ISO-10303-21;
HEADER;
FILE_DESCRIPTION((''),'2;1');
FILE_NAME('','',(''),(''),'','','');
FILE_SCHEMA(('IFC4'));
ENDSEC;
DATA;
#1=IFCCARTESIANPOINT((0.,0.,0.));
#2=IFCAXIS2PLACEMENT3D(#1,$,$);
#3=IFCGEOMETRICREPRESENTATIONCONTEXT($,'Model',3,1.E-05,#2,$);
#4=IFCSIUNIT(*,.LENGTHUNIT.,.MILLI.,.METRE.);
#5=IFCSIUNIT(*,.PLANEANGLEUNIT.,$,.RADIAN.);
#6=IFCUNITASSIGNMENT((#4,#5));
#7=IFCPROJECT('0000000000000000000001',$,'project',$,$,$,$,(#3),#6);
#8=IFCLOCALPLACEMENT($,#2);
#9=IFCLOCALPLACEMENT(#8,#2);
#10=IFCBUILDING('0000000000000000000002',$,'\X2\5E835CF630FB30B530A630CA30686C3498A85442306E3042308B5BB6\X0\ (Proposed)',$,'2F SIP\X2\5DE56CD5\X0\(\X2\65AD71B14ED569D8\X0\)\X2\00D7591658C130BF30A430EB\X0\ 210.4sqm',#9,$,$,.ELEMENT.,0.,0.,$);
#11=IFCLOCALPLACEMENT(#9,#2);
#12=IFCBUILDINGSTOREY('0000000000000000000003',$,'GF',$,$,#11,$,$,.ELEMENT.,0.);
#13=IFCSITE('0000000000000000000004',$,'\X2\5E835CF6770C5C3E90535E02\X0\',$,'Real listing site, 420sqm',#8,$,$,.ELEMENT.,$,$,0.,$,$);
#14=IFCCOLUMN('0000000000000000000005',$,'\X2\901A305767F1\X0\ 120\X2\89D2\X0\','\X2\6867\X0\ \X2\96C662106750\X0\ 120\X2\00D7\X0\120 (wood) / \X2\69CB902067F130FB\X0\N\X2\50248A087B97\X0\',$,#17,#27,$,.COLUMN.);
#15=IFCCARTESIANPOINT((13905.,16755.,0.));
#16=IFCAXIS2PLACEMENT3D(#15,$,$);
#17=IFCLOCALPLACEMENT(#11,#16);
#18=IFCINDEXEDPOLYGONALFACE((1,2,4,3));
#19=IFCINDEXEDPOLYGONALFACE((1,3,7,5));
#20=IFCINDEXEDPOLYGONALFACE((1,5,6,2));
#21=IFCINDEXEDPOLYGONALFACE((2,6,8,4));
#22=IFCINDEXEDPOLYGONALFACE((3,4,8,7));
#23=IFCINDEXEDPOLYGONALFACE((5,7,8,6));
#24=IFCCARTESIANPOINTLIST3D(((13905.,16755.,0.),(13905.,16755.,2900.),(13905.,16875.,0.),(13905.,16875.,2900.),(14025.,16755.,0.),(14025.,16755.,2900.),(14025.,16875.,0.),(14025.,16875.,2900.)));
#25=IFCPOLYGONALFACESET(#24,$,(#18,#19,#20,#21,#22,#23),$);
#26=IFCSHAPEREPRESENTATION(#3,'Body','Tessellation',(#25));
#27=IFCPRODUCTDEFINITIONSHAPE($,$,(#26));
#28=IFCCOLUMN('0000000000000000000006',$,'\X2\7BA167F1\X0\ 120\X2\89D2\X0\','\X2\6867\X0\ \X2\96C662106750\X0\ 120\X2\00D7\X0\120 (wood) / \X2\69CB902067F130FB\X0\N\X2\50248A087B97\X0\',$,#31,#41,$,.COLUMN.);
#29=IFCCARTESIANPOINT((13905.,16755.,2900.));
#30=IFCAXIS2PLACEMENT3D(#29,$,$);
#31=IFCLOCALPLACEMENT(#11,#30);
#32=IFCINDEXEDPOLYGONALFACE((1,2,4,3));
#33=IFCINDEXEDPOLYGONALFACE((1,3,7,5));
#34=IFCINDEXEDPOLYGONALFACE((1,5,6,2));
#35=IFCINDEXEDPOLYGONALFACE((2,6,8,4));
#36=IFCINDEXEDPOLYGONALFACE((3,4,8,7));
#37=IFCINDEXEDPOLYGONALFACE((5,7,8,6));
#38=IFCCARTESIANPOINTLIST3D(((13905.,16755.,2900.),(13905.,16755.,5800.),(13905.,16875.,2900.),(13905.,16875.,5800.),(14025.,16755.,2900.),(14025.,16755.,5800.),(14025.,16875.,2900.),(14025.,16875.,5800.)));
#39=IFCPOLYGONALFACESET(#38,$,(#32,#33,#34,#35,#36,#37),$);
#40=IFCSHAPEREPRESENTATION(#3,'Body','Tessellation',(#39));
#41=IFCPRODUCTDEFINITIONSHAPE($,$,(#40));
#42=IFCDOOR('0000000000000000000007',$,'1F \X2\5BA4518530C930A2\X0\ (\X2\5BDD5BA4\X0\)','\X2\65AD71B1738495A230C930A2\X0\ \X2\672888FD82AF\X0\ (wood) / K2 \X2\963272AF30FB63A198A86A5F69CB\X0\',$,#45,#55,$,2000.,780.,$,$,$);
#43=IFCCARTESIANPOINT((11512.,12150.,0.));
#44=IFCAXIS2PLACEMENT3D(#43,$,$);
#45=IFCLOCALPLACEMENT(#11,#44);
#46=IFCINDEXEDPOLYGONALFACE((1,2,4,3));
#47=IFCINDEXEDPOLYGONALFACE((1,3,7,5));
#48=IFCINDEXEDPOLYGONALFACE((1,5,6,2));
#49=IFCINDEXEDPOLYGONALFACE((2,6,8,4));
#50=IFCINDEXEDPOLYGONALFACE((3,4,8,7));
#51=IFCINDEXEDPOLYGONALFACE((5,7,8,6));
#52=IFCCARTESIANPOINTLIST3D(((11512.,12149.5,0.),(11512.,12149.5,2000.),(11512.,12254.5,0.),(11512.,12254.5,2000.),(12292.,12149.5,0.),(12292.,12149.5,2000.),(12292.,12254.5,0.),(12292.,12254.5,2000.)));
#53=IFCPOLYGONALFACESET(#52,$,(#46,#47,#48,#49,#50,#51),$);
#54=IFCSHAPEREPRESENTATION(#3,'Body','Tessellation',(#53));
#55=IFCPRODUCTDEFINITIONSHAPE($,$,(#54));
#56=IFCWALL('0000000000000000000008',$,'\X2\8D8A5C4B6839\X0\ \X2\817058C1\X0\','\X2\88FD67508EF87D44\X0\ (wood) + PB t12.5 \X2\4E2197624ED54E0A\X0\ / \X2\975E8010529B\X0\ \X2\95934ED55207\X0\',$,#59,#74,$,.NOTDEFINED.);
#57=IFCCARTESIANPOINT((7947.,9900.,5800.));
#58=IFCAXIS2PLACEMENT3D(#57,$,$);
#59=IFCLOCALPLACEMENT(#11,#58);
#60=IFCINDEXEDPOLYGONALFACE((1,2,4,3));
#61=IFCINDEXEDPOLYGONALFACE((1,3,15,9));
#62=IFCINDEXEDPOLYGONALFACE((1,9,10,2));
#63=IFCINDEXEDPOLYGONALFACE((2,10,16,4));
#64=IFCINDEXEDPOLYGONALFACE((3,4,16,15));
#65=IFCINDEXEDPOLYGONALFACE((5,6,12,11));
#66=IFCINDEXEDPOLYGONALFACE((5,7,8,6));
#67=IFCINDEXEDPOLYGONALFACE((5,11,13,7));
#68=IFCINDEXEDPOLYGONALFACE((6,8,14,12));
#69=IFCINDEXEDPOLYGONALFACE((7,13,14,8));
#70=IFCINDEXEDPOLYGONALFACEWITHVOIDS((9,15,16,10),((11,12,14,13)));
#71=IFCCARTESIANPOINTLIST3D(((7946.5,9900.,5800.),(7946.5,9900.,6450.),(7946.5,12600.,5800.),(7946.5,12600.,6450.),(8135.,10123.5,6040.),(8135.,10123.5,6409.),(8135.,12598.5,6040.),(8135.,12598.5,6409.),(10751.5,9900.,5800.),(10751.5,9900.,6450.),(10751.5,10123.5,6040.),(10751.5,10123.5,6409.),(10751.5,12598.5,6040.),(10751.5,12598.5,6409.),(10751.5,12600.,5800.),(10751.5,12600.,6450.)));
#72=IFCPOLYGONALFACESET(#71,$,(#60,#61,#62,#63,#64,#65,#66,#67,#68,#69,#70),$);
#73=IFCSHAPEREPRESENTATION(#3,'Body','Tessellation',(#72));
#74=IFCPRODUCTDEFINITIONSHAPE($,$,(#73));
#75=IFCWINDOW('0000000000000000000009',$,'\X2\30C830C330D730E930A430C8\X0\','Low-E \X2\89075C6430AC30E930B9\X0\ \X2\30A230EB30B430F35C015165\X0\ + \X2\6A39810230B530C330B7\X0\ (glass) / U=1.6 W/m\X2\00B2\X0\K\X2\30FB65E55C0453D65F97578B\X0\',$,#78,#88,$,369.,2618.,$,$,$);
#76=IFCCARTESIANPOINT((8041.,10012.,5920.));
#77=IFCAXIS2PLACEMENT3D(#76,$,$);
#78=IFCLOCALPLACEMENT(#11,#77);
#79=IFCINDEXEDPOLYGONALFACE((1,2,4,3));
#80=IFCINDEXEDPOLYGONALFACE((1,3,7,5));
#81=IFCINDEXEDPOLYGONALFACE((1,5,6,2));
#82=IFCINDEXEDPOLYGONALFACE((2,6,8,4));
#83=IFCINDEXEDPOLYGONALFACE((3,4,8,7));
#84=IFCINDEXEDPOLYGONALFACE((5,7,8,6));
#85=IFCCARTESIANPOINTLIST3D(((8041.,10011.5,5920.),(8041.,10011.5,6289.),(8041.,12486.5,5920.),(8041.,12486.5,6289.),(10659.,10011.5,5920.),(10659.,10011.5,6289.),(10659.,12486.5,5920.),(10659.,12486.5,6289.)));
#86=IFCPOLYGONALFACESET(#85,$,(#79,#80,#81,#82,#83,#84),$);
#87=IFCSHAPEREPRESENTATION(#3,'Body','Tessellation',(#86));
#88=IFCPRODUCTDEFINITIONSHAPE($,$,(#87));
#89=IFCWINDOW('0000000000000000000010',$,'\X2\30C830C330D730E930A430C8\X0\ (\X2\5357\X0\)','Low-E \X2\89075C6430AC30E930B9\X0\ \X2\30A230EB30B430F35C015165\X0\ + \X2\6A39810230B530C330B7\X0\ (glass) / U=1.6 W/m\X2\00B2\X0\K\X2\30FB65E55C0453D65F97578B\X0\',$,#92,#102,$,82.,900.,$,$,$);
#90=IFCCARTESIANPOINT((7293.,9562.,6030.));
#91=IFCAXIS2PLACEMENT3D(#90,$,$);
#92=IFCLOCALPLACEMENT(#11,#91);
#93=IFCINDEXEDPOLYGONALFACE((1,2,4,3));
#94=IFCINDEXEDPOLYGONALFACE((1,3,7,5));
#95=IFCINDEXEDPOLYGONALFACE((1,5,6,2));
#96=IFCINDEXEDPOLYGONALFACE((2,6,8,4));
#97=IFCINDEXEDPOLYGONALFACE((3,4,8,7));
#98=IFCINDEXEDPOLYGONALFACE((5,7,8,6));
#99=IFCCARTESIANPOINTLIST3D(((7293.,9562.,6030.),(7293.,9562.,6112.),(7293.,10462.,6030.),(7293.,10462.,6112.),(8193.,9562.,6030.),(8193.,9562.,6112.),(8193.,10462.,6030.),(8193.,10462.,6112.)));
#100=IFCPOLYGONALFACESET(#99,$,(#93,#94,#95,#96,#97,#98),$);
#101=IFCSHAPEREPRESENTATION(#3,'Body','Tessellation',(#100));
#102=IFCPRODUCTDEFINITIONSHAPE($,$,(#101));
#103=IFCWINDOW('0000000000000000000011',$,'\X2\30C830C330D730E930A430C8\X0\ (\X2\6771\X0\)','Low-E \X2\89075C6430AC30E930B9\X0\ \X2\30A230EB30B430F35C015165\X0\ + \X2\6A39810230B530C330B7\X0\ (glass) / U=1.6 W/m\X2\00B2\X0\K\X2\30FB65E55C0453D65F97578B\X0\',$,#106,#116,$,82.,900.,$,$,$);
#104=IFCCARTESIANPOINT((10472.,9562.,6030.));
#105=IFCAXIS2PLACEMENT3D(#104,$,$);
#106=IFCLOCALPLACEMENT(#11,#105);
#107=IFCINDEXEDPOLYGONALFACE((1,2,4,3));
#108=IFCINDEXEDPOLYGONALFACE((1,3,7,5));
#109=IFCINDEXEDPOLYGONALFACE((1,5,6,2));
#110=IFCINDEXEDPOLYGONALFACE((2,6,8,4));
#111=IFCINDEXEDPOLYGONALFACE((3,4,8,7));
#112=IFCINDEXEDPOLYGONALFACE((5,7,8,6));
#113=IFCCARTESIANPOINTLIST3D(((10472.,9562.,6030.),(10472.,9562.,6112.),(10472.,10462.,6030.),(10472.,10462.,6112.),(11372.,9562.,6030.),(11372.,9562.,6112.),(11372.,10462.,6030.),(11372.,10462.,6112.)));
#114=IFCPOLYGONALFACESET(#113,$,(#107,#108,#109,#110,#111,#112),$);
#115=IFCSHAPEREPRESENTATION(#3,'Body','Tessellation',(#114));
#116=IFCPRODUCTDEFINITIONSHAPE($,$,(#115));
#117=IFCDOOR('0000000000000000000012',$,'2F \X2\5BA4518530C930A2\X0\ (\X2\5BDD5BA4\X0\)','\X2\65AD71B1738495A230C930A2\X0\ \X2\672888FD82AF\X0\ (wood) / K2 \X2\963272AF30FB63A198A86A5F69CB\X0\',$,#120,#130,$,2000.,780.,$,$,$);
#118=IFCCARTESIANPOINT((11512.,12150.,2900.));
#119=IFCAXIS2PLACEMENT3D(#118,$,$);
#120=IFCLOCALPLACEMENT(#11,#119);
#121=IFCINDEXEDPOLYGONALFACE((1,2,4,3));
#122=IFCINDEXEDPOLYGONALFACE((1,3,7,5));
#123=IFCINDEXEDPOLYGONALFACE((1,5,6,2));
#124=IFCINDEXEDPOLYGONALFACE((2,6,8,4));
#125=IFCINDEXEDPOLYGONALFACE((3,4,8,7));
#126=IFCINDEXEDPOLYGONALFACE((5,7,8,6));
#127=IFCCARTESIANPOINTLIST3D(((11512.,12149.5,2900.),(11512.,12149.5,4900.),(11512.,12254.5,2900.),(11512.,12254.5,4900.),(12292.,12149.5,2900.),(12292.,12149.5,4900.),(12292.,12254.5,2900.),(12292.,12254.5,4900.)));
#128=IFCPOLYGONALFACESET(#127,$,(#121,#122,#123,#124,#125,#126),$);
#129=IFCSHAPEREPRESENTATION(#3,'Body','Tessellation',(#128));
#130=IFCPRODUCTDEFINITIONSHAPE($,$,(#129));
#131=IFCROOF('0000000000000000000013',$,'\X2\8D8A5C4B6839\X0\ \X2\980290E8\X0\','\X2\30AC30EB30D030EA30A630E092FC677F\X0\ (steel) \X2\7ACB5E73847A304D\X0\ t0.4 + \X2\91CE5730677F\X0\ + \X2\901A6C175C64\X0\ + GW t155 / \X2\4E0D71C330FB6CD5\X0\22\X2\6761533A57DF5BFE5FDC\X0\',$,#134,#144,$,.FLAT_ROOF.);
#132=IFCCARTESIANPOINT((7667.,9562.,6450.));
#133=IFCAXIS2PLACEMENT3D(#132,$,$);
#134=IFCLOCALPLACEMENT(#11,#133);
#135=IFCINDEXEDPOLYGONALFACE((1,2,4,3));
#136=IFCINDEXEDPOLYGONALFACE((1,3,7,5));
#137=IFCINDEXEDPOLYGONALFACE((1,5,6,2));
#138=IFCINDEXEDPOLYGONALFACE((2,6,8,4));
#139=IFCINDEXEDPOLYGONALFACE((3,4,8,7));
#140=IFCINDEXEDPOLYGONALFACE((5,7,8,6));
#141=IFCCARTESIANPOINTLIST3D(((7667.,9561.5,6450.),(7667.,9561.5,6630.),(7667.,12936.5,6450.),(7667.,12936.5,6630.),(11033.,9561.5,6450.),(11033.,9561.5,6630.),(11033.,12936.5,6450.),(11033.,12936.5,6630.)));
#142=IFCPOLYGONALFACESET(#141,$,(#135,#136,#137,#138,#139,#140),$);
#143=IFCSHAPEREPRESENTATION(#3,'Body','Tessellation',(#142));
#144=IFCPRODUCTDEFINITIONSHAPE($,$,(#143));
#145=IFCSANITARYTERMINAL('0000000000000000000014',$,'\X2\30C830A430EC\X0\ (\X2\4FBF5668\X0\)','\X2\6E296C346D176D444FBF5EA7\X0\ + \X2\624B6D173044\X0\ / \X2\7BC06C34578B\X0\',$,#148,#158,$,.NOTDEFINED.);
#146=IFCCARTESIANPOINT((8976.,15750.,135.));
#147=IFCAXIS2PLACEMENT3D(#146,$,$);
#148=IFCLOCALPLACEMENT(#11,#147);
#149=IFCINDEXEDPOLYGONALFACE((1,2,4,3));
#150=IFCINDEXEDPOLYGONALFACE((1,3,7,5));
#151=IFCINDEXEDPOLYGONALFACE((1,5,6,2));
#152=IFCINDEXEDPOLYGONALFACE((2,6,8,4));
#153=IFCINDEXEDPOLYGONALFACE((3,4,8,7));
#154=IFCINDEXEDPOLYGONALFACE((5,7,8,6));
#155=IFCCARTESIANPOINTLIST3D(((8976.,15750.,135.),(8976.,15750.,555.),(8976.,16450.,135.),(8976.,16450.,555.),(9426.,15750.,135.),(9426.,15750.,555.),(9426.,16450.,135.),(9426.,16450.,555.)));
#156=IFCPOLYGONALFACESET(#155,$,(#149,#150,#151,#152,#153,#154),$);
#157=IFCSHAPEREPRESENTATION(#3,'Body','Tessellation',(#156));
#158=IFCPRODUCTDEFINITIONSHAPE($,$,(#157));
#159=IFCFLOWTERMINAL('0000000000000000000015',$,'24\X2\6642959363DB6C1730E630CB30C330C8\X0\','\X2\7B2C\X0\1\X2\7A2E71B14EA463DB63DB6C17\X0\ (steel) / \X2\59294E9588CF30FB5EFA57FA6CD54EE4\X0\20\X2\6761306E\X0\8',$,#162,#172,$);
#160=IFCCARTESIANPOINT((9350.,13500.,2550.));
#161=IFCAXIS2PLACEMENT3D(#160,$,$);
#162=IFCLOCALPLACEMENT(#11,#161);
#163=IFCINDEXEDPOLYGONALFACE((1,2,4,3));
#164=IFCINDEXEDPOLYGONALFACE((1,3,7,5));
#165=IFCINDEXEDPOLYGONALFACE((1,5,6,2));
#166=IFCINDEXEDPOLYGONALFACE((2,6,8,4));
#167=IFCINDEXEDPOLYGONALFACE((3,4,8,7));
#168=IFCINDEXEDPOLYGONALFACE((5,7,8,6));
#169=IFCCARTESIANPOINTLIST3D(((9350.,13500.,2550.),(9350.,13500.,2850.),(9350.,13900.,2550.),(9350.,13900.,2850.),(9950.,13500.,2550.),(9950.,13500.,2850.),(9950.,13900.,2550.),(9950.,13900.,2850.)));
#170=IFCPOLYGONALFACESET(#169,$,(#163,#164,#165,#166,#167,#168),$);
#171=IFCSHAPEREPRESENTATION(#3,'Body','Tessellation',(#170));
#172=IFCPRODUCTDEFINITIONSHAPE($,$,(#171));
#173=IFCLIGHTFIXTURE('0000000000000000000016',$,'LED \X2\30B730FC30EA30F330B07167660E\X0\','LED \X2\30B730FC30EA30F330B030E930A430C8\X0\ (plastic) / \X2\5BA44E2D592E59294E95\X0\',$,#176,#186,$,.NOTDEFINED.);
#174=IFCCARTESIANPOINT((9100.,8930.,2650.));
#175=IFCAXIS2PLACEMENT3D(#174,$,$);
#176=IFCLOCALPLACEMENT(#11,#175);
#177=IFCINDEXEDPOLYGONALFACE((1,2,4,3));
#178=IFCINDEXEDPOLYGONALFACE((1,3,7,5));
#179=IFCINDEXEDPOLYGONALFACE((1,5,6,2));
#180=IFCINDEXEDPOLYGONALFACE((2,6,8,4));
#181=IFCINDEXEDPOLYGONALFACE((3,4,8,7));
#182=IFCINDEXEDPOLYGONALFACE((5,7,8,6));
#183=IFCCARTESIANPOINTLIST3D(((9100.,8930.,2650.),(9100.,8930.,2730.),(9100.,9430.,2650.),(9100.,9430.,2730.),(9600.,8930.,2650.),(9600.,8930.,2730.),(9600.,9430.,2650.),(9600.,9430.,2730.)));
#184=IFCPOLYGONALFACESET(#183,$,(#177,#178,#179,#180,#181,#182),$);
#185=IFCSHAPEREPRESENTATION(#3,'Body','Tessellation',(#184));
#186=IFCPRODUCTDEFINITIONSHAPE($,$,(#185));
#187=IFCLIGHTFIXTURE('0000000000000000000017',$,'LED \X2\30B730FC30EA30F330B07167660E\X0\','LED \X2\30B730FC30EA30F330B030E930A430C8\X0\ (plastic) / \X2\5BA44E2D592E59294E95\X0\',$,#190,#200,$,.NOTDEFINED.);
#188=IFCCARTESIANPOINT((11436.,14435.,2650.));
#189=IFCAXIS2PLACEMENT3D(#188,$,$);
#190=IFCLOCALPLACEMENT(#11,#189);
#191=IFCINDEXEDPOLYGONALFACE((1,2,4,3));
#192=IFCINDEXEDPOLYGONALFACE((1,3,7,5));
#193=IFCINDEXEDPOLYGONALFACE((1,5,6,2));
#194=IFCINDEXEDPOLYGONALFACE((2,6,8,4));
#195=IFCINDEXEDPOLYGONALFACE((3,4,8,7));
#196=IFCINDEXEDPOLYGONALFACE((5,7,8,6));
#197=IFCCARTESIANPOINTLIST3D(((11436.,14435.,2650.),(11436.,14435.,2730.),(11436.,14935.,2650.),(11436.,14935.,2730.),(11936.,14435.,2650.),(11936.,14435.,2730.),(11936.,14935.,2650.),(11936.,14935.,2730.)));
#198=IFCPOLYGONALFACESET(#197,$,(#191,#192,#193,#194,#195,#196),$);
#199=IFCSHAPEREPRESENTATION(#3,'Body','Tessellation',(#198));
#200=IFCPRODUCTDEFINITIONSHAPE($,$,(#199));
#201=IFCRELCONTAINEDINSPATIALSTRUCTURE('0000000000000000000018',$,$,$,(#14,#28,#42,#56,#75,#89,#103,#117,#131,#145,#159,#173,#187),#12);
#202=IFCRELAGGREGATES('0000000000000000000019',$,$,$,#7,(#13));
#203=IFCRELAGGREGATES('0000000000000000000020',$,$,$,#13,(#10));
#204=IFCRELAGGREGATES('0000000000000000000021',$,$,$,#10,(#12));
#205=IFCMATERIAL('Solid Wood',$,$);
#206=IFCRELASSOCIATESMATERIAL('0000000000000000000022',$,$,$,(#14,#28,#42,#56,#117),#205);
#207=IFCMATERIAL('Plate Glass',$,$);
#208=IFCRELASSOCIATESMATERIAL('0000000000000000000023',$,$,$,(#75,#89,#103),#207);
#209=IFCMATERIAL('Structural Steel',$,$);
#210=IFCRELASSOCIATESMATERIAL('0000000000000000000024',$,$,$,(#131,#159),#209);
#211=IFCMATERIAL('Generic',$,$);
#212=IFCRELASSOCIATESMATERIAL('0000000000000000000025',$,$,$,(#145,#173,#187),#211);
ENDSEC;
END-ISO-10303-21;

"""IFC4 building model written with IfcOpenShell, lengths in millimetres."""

from ifc_helpers import new_model, si_unit, frame, frame_2d, origin, place, context, project, spatial, rectangle, extrude, material, element, fill, save


model = new_model("IFC4")

# Units and contexts
model_context = context("Model", 3, precision=1e-05, world=origin())
ifc_project = project(units=[si_unit("LENGTHUNIT", "METRE", prefix="MILLI"), si_unit("PLANEANGLEUNIT", "RADIAN")], contexts=[model_context])

# Site, building, storey
site_placement = place(None, origin())
site = spatial("IfcSite", under=ifc_project, at=site_placement, Name="広島県尾道市", ObjectType="Real listing site, 420sqm", CompositionType="ELEMENT", RefElevation=0.0)
building_placement = place(site_placement, origin())
building = spatial("IfcBuilding", under=site, at=building_placement, Name="広島・サウナと水風呂のある家 (Proposed)", ObjectType="2F SIP工法(断熱仕様)×外壁タイル 210.4sqm", CompositionType="ELEMENT", ElevationOfRefHeight=0.0, ElevationOfTerrain=0.0)
storey_placement = place(building_placement, origin())
storey = spatial("IfcBuildingStorey", under=building, at=storey_placement, Name="GF", CompositionType="ELEMENT", Elevation=0.0)

# Columns
ifc_material_1 = material(Name="Solid Wood")
column_1_placement = place(storey_placement, frame((13905.0, 16755.0, 0.0)))
element("IfcColumn", 1, at=column_1_placement, inside=storey, material=ifc_material_1, Name="通し柱 120角", Description="桧 集成材 120×120 (wood) / 構造柱・N値計算", PredefinedType="COLUMN", context=model_context, shape_type="SweptSolid", body=[
    extrude(rectangle(XDim=120.0, YDim=120.0, at=frame_2d((60.0, 60.0))), frame((13905.0, 16755.0, 0.0)), (0.0, 0.0, 1.0), 2900.0),
])
column_2_placement = place(storey_placement, frame((13905.0, 16755.0, 2900.0)))
element("IfcColumn", 2, at=column_2_placement, inside=storey, material=ifc_material_1, Name="管柱 120角", Description="桧 集成材 120×120 (wood) / 構造柱・N値計算", PredefinedType="COLUMN", context=model_context, shape_type="SweptSolid", body=[
    extrude(rectangle(XDim=120.0, YDim=120.0, at=frame_2d((60.0, 60.0))), frame((13905.0, 16755.0, 2900.0)), (0.0, 0.0, 1.0), 2900.0),
])

# Door
door_1_placement = place(storey_placement, frame((11512.0, 12150.0, 0.0)))
element("IfcDoor", 3, at=door_1_placement, inside=storey, material=ifc_material_1, Name="1F 室内ドア (寝室)", Description="断熱玄関ドア 木製芯 (wood) / K2 防犯・採風機構", OverallHeight=2000.0, OverallWidth=780.0, context=model_context, shape_type="SweptSolid", body=[
    extrude(rectangle(XDim=780.0, YDim=105.0, at=frame_2d((390.0, 52.0))), frame((11512.0, 12150.0, 0.0)), (0.0, 0.0, 1.0), 2000.0),
])

# Wall, openings, windows
wall_1_placement = place(storey_placement, frame((7947.0, 9900.0, 5800.0)))
wall_1 = element("IfcWall", 4, at=wall_1_placement, inside=storey, material=ifc_material_1, Name="越屋根 腰壁", Description="製材軸組 (wood) + PB t12.5 両面仕上 / 非耐力 間仕切", PredefinedType="NOTDEFINED", context=model_context, shape_type="SweptSolid", body=[
    extrude(rectangle(XDim=2805.0, YDim=2700.0, at=frame_2d((1402.0, 1350.0))), frame((7947.0, 9900.0, 5800.0)), (0.0, 0.0, 1.0), 650.0),
])
opening_1_placement = place(storey_placement, frame((8041.0, 10012.0, 5920.0)))
opening_1 = element("IfcOpeningElement", 5, at=opening_1_placement, cuts=wall_1, PredefinedType="NOTDEFINED", context=model_context, shape_type="SweptSolid", body=[
    extrude(rectangle(XDim=2618.0, YDim=2475.0, at=frame_2d((1309.0, 1237.0))), frame((8041.0, 10012.0, 5920.0)), (0.0, 0.0, 1.0), 369.0),
])
opening_2_placement = place(storey_placement, frame((7293.0, 9562.0, 6030.0)))
opening_2 = element("IfcOpeningElement", 6, at=opening_2_placement, cuts=wall_1, PredefinedType="NOTDEFINED", context=model_context, shape_type="SweptSolid", body=[
    extrude(rectangle(XDim=900.0, YDim=900.0, at=frame_2d((450.0, 450.0))), frame((7293.0, 9562.0, 6030.0)), (0.0, 0.0, 1.0), 82.0),
])
opening_3_placement = place(storey_placement, frame((10472.0, 9562.0, 6030.0)))
opening_3 = element("IfcOpeningElement", 7, at=opening_3_placement, cuts=wall_1, PredefinedType="NOTDEFINED", context=model_context, shape_type="SweptSolid", body=[
    extrude(rectangle(XDim=900.0, YDim=900.0, at=frame_2d((450.0, 450.0))), frame((10472.0, 9562.0, 6030.0)), (0.0, 0.0, 1.0), 82.0),
])
ifc_material_2 = material(Name="Plate Glass")
window_1_placement = place(storey_placement, frame((8041.0, 10012.0, 5920.0)))
window_1 = element("IfcWindow", 8, at=window_1_placement, inside=storey, material=ifc_material_2, Name="トップライト", Description="Low-E 複層ガラス アルゴン封入 + 樹脂サッシ (glass) / U=1.6 W/m²K・日射取得型", OverallHeight=369.0, OverallWidth=2618.0, context=model_context, shape_type="SweptSolid", body=[
    extrude(rectangle(XDim=2618.0, YDim=2475.0, at=frame_2d((1309.0, 1237.0))), frame((8041.0, 10012.0, 5920.0)), (0.0, 0.0, 1.0), 369.0),
])
fill(opening_1, window_1)
window_2_placement = place(storey_placement, frame((7293.0, 9562.0, 6030.0)))
window_2 = element("IfcWindow", 9, at=window_2_placement, inside=storey, material=ifc_material_2, Name="トップライト (南)", Description="Low-E 複層ガラス アルゴン封入 + 樹脂サッシ (glass) / U=1.6 W/m²K・日射取得型", OverallHeight=82.0, OverallWidth=900.0, context=model_context, shape_type="SweptSolid", body=[
    extrude(rectangle(XDim=900.0, YDim=900.0, at=frame_2d((450.0, 450.0))), frame((7293.0, 9562.0, 6030.0)), (0.0, 0.0, 1.0), 82.0),
])
fill(opening_2, window_2)
window_3_placement = place(storey_placement, frame((10472.0, 9562.0, 6030.0)))
window_3 = element("IfcWindow", 10, at=window_3_placement, inside=storey, material=ifc_material_2, Name="トップライト (東)", Description="Low-E 複層ガラス アルゴン封入 + 樹脂サッシ (glass) / U=1.6 W/m²K・日射取得型", OverallHeight=82.0, OverallWidth=900.0, context=model_context, shape_type="SweptSolid", body=[
    extrude(rectangle(XDim=900.0, YDim=900.0, at=frame_2d((450.0, 450.0))), frame((10472.0, 9562.0, 6030.0)), (0.0, 0.0, 1.0), 82.0),
])
fill(opening_3, window_3)

# Door
door_2_placement = place(storey_placement, frame((11512.0, 12150.0, 2900.0)))
element("IfcDoor", 11, at=door_2_placement, inside=storey, material=ifc_material_1, Name="2F 室内ドア (寝室)", Description="断熱玄関ドア 木製芯 (wood) / K2 防犯・採風機構", OverallHeight=2000.0, OverallWidth=780.0, context=model_context, shape_type="SweptSolid", body=[
    extrude(rectangle(XDim=780.0, YDim=105.0, at=frame_2d((390.0, 52.0))), frame((11512.0, 12150.0, 2900.0)), (0.0, 0.0, 1.0), 2000.0),
])

# Roof
ifc_material_3 = material(Name="Structural Steel")
roof_placement = place(storey_placement, frame((7667.0, 9562.0, 6450.0)))
element("IfcRoof", 12, at=roof_placement, inside=storey, material=ifc_material_3, Name="越屋根 頂部", Description="ガルバリウム鋼板 (steel) 立平葺き t0.4 + 野地板 + 通気層 + GW t155 / 不燃・法22条区域対応", PredefinedType="FLAT_ROOF", context=model_context, shape_type="SweptSolid", body=[
    extrude(rectangle(XDim=3366.0, YDim=3375.0, at=frame_2d((1683.0, 1687.0))), frame((7667.0, 9562.0, 6450.0)), (0.0, 0.0, 1.0), 180.0),
])

# Sanitary terminal
ifc_material_4 = material(Name="Generic")
sanitary_terminal_placement = place(storey_placement, frame((8976.0, 15750.0, 135.0)))
element("IfcSanitaryTerminal", 13, at=sanitary_terminal_placement, inside=storey, material=ifc_material_4, Name="トイレ (便器)", Description="温水洗浄便座 + 手洗い / 節水型", PredefinedType="NOTDEFINED", context=model_context, shape_type="SweptSolid", body=[
    extrude(rectangle(XDim=450.0, YDim=700.0, at=frame_2d((225.0, 350.0))), frame((8976.0, 15750.0, 135.0)), (0.0, 0.0, 1.0), 420.0),
])

# Flow terminal
flow_terminal_placement = place(storey_placement, frame((9350.0, 13500.0, 2550.0)))
element("IfcFlowTerminal", 14, at=flow_terminal_placement, inside=storey, material=ifc_material_3, Name="24時間換気ユニット", Description="第1種熱交換換気 (steel) / 天井裏・建基法令20条の8", context=model_context, shape_type="SweptSolid", body=[
    extrude(rectangle(XDim=600.0, YDim=400.0, at=frame_2d((300.0, 200.0))), frame((9350.0, 13500.0, 2550.0)), (0.0, 0.0, 1.0), 300.0),
])

# Light fixtures
light_fixture_1_placement = place(storey_placement, frame((9100.0, 8930.0, 2650.0)))
element("IfcLightFixture", 15, at=light_fixture_1_placement, inside=storey, material=ifc_material_4, Name="LED シーリング照明", Description="LED シーリングライト (plastic) / 室中央天井", PredefinedType="NOTDEFINED", context=model_context, shape_type="SweptSolid", body=[
    extrude(rectangle(XDim=500.0, YDim=500.0, at=frame_2d((250.0, 250.0))), frame((9100.0, 8930.0, 2650.0)), (0.0, 0.0, 1.0), 80.0),
])
light_fixture_2_placement = place(storey_placement, frame((11436.0, 14435.0, 2650.0)))
element("IfcLightFixture", 16, at=light_fixture_2_placement, inside=storey, material=ifc_material_4, Name="LED シーリング照明", Description="LED シーリングライト (plastic) / 室中央天井", PredefinedType="NOTDEFINED", context=model_context, shape_type="SweptSolid", body=[
    extrude(rectangle(XDim=500.0, YDim=500.0, at=frame_2d((250.0, 250.0))), frame((11436.0, 14435.0, 2650.0)), (0.0, 0.0, 1.0), 80.0),
])

save(model, "model.ifc")
